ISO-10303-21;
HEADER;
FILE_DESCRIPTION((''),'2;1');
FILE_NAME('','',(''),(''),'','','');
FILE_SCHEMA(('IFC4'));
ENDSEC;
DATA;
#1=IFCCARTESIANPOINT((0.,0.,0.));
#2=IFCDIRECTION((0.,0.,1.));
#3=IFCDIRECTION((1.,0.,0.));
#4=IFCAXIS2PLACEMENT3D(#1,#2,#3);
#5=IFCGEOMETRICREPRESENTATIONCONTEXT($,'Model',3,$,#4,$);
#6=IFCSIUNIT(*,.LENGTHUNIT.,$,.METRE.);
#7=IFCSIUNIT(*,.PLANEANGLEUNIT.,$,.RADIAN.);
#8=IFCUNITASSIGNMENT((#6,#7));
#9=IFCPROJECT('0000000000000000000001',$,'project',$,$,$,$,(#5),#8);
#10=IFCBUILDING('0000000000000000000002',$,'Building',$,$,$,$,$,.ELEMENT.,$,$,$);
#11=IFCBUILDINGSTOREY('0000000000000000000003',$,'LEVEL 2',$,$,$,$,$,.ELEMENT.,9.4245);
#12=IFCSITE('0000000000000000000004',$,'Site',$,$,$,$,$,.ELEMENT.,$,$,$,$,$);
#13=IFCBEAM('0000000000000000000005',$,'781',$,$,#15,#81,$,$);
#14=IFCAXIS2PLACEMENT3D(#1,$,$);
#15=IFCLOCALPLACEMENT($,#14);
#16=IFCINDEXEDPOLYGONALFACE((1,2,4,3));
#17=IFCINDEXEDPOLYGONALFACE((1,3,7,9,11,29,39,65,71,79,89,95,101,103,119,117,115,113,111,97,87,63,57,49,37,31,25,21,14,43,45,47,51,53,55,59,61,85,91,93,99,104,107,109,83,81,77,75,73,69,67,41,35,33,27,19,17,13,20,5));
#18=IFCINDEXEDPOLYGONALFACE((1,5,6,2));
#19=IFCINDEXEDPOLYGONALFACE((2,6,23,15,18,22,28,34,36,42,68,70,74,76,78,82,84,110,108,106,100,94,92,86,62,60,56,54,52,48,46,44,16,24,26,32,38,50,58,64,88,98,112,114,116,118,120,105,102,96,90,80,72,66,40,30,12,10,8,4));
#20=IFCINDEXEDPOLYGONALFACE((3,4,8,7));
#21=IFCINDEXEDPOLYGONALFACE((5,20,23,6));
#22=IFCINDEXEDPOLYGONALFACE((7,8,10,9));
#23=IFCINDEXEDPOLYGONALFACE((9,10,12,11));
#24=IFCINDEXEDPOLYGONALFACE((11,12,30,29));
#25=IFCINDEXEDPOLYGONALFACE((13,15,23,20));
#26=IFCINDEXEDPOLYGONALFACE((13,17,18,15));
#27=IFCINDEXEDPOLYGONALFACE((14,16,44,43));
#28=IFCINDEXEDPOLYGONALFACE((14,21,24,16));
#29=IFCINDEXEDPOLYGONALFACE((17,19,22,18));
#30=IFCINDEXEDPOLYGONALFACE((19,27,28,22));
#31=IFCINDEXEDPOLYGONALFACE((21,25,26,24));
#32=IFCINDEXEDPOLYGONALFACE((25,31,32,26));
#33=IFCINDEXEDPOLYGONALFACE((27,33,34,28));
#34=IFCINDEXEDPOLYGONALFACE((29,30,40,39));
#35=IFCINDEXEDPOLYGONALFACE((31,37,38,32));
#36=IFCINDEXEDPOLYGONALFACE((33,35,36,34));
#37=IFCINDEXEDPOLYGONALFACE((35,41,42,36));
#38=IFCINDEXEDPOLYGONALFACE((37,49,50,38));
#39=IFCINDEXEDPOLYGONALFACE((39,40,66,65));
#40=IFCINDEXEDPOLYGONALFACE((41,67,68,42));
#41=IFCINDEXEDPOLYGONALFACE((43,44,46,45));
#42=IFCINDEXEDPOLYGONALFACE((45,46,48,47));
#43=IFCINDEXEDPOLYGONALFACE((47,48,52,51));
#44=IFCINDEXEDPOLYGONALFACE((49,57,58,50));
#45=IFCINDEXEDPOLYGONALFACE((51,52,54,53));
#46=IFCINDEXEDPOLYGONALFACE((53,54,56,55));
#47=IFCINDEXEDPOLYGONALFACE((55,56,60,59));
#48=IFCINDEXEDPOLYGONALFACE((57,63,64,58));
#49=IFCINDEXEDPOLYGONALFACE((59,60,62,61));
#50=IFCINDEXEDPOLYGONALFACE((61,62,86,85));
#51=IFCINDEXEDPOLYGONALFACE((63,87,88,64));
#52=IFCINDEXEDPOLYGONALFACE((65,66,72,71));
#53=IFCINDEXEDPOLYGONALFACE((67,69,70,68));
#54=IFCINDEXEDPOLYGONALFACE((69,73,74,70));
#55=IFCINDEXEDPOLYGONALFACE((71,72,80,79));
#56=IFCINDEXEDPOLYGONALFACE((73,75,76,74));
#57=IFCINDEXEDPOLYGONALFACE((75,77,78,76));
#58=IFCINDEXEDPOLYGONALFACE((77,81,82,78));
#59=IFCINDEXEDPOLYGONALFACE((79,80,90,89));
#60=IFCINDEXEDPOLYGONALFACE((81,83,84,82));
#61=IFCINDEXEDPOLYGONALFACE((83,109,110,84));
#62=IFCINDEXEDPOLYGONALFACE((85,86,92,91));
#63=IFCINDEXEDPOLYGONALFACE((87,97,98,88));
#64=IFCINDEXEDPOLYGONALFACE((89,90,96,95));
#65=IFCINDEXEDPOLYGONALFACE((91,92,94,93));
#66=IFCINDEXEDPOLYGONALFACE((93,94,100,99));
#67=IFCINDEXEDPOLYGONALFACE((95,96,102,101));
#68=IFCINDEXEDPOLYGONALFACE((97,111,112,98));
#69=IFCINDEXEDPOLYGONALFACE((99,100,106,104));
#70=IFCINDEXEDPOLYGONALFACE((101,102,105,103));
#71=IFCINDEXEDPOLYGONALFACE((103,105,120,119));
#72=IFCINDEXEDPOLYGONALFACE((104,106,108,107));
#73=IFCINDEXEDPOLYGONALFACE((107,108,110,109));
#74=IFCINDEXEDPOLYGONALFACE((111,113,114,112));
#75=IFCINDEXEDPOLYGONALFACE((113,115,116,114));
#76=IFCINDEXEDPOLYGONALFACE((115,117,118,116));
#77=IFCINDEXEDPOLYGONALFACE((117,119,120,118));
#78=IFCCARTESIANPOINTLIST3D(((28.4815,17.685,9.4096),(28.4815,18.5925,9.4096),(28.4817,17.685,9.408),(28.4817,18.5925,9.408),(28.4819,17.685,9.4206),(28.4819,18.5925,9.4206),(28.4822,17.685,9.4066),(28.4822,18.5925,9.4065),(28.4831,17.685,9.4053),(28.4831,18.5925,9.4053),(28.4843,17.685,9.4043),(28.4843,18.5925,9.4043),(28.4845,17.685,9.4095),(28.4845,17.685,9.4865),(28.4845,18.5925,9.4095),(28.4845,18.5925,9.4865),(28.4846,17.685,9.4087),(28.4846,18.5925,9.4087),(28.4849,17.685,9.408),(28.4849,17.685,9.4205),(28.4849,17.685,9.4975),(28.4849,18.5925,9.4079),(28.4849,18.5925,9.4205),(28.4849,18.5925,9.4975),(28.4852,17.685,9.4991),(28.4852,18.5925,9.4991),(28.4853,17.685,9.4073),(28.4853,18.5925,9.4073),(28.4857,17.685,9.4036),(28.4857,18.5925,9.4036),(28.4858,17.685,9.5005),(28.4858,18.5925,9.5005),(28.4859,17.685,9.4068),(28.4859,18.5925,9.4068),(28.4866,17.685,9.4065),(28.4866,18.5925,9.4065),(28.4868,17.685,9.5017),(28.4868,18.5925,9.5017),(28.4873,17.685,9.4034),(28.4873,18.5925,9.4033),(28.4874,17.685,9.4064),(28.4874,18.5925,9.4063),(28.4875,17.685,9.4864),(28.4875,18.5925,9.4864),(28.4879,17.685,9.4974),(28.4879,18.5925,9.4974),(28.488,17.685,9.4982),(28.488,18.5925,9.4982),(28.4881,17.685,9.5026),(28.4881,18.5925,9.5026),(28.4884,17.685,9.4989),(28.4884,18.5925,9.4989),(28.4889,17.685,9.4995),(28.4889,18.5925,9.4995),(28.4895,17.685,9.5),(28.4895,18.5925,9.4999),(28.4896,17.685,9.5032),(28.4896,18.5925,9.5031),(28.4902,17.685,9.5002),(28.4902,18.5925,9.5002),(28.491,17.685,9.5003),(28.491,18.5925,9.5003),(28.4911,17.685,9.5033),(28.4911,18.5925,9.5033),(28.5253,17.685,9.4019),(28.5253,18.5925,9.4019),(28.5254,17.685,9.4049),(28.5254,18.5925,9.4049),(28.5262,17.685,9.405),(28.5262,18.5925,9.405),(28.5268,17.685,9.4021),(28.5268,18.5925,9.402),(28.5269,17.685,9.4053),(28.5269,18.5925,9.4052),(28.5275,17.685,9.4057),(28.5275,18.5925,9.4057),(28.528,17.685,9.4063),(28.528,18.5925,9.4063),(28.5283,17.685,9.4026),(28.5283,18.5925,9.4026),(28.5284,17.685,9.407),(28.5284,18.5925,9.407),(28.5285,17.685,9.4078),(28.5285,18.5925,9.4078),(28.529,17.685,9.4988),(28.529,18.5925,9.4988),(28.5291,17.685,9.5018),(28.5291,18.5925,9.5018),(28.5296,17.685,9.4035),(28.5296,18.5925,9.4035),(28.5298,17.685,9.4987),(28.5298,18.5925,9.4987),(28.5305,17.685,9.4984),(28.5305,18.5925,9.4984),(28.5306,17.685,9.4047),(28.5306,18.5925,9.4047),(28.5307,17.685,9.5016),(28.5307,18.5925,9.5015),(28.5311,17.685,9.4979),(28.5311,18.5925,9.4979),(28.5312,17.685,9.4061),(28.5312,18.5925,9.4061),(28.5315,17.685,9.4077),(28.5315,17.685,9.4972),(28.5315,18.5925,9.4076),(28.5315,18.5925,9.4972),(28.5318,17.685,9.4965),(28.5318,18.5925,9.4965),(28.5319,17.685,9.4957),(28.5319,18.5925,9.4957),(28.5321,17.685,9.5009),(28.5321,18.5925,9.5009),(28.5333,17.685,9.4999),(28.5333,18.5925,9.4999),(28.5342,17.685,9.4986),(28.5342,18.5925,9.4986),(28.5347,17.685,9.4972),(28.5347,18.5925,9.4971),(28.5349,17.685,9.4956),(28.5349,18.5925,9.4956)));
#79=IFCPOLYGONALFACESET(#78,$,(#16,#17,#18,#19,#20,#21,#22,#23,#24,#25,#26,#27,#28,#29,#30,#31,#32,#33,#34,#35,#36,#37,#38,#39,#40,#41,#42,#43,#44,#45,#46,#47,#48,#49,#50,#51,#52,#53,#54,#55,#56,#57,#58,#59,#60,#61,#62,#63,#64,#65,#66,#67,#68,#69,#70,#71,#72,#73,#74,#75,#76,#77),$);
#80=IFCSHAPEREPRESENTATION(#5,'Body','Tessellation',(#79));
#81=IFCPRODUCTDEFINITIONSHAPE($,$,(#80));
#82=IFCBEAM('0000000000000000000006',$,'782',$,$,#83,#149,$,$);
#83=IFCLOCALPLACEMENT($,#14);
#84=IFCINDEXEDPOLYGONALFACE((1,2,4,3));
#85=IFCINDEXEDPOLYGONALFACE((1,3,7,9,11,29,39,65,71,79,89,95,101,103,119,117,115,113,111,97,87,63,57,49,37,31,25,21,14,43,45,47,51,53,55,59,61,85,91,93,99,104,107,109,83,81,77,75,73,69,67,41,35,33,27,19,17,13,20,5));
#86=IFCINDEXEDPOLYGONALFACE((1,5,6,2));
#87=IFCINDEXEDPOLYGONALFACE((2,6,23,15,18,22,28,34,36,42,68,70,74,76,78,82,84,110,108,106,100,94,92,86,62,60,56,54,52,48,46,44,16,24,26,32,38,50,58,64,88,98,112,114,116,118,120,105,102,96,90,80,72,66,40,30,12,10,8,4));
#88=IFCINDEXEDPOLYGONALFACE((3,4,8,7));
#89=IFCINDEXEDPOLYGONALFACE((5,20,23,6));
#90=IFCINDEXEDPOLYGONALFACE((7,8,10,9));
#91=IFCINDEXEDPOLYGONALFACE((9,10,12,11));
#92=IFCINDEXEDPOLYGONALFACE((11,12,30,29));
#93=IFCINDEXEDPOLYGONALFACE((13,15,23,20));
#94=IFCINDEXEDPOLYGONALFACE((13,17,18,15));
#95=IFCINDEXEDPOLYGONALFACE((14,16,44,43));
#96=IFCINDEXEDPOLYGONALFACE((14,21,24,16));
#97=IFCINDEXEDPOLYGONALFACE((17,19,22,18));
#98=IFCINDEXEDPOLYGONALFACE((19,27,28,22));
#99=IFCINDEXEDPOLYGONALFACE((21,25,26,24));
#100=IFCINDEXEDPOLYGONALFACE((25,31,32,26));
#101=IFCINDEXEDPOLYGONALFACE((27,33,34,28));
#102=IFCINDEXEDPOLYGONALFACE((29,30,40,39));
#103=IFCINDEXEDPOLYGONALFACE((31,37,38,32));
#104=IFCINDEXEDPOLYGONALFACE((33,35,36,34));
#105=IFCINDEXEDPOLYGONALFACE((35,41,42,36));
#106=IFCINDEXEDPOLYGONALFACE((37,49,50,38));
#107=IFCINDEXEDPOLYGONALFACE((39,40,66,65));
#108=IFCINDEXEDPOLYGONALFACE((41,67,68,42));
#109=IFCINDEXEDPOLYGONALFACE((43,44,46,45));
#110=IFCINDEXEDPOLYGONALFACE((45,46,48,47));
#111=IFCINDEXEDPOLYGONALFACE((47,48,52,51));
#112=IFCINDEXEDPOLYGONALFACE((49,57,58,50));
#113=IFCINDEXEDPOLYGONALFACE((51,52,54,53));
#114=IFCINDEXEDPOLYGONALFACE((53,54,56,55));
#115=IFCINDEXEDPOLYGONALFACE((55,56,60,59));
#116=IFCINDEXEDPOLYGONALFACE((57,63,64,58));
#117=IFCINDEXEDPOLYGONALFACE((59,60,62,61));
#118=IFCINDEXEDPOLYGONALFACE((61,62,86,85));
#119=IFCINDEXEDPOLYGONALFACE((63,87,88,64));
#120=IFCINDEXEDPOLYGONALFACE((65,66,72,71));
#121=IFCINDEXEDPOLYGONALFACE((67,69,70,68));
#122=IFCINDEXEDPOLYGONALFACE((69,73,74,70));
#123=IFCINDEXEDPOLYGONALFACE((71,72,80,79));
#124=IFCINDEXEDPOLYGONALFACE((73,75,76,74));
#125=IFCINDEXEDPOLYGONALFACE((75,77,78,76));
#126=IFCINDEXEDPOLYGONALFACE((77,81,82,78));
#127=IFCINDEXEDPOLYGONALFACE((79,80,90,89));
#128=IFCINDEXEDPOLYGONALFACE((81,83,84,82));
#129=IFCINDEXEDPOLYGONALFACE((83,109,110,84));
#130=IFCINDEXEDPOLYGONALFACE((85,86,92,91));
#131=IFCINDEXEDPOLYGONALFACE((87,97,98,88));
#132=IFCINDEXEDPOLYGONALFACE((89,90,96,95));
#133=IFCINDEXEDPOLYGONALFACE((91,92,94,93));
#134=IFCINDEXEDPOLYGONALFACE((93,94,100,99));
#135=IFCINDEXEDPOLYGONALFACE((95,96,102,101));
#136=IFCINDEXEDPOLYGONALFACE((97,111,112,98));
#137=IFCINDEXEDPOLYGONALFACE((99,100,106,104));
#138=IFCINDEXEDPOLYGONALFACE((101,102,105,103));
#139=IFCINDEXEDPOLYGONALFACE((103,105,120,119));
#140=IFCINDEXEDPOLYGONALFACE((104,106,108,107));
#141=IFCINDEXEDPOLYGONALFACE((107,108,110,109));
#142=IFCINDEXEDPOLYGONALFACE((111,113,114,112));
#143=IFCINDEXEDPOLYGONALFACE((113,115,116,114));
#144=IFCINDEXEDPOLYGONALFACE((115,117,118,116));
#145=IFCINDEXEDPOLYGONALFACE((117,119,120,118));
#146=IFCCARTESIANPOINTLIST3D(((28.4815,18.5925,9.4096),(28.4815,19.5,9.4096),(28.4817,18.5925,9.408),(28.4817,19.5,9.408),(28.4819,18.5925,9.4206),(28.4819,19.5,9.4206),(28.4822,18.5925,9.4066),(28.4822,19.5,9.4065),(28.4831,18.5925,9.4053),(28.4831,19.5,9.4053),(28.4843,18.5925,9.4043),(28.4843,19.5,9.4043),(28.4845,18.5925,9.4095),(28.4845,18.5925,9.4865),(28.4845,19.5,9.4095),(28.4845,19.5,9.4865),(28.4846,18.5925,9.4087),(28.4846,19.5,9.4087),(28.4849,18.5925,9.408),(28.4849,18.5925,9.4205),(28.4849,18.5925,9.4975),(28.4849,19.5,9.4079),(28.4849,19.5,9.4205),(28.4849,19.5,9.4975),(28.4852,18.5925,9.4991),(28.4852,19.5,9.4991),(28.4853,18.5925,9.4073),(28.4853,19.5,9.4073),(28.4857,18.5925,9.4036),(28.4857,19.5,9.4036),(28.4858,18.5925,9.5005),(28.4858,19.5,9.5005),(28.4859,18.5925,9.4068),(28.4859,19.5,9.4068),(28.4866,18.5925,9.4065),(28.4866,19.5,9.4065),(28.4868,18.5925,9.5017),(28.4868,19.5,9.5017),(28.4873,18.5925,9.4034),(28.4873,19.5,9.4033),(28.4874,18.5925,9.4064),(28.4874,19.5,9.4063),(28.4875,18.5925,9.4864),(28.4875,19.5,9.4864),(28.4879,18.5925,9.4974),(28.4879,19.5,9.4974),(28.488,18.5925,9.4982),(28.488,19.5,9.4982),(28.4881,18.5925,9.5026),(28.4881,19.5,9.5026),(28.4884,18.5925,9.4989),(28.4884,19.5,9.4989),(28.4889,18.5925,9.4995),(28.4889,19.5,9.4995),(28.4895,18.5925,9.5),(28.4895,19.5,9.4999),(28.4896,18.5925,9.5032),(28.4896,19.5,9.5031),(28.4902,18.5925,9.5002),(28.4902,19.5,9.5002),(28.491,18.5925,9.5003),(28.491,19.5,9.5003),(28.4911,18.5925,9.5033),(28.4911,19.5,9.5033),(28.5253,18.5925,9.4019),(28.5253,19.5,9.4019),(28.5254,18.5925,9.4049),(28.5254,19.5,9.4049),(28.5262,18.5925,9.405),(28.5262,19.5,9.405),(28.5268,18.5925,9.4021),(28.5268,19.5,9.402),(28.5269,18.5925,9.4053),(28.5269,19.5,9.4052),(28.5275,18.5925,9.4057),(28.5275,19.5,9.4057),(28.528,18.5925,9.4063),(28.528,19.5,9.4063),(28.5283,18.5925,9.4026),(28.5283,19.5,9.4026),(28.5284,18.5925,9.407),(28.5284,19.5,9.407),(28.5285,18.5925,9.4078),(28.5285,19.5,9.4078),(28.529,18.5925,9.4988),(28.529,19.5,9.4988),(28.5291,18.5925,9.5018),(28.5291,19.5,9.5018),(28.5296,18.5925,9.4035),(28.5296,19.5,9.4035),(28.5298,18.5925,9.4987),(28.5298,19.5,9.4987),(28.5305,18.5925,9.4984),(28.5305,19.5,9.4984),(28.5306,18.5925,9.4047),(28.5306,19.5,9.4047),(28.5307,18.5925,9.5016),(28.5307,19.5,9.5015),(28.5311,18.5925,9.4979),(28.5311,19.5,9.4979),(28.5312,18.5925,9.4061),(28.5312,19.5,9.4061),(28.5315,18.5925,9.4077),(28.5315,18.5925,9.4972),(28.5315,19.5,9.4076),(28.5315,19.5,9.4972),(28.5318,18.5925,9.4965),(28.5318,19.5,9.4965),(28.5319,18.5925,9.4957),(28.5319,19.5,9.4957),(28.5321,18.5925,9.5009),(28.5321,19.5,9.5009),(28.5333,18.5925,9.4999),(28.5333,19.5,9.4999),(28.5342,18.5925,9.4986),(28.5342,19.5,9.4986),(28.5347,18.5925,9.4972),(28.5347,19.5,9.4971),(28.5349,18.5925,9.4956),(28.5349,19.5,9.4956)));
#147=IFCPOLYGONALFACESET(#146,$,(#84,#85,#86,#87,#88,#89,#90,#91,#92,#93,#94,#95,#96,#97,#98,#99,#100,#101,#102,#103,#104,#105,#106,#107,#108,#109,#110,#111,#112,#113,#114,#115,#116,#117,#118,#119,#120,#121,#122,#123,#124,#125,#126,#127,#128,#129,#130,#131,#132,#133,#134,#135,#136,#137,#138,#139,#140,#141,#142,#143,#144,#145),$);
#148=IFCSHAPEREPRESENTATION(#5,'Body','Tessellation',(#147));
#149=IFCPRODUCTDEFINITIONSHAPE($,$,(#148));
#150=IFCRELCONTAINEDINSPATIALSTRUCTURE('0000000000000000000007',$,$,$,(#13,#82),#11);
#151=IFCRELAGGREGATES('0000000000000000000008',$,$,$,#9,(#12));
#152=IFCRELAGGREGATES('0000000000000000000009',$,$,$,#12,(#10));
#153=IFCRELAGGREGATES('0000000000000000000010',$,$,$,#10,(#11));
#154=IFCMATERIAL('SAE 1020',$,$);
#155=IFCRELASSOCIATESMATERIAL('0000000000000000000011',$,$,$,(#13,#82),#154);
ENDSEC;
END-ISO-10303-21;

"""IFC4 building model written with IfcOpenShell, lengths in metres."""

from ifc_helpers import new_model, si_unit, frame, origin_with_axes, origin_2d_with_axis, place, context, project, spatial, c_section, extrude, material, material_profile, profile_set, profile_usage, element, save


model = new_model("IFC4")

# Units and contexts
model_context = context("Model", 3, world=origin_with_axes())
ifc_project = project(units=[si_unit("LENGTHUNIT", "METRE"), si_unit("PLANEANGLEUNIT", "RADIAN")], contexts=[model_context])

# Site, building, storey
site = spatial("IfcSite", under=ifc_project, Name="Site", CompositionType="ELEMENT")
building = spatial("IfcBuilding", under=site, Name="Building", CompositionType="ELEMENT")
storey = spatial("IfcBuildingStorey", under=building, Name="LEVEL 2", CompositionType="ELEMENT", Elevation=9.4245)

# Beams
ifc_material = material(Name="SAE 1020")
ifc_material_profile_1 = material_profile(ifc_material, c_section(Depth=0.1, Width=0.05, WallThickness=0.003, Girth=0.017, InternalFilletRadius=0.003, at=origin_2d_with_axis()))
ifc_profile_set_1 = profile_set([ifc_material_profile_1])
ifc_profile_usage_1 = profile_usage(ifc_profile_set_1, cardinal=10)
beam_1_placement = place(None, frame((28.5082, 17.685, 9.4526), z_axis=(0.0, 1.0, -0.00003), x_axis=(-0.999256, 0.000001, 0.038562)))
element("IfcBeam", 1, at=beam_1_placement, inside=storey, material=ifc_profile_usage_1, Name="781", context=model_context, shape_type="SweptSolid", body=[
    extrude(c_section(Depth=0.1, Width=0.05, WallThickness=0.003, Girth=0.017, InternalFilletRadius=0.003, at=origin_2d_with_axis()), origin_with_axes(), (0.0, 0.0, 1.0), 0.9075),
])
ifc_material_profile_2 = material_profile(ifc_material, c_section(Depth=0.1, Width=0.05, WallThickness=0.003, Girth=0.017, InternalFilletRadius=0.003, at=origin_2d_with_axis()))
ifc_profile_set_2 = profile_set([ifc_material_profile_2])
ifc_profile_usage_2 = profile_usage(ifc_profile_set_2, cardinal=10)
beam_2_placement = place(None, frame((28.5082, 18.5925, 9.4526), z_axis=(0.0, 1.0, -0.00003), x_axis=(-0.999256, 0.000001, 0.038562)))
element("IfcBeam", 2, at=beam_2_placement, inside=storey, material=ifc_profile_usage_2, Name="782", context=model_context, shape_type="SweptSolid", body=[
    extrude(c_section(Depth=0.1, Width=0.05, WallThickness=0.003, Girth=0.017, InternalFilletRadius=0.003, at=origin_2d_with_axis()), origin_with_axes(), (0.0, 0.0, 1.0), 0.9075),
])

save(model, "model.ifc")
